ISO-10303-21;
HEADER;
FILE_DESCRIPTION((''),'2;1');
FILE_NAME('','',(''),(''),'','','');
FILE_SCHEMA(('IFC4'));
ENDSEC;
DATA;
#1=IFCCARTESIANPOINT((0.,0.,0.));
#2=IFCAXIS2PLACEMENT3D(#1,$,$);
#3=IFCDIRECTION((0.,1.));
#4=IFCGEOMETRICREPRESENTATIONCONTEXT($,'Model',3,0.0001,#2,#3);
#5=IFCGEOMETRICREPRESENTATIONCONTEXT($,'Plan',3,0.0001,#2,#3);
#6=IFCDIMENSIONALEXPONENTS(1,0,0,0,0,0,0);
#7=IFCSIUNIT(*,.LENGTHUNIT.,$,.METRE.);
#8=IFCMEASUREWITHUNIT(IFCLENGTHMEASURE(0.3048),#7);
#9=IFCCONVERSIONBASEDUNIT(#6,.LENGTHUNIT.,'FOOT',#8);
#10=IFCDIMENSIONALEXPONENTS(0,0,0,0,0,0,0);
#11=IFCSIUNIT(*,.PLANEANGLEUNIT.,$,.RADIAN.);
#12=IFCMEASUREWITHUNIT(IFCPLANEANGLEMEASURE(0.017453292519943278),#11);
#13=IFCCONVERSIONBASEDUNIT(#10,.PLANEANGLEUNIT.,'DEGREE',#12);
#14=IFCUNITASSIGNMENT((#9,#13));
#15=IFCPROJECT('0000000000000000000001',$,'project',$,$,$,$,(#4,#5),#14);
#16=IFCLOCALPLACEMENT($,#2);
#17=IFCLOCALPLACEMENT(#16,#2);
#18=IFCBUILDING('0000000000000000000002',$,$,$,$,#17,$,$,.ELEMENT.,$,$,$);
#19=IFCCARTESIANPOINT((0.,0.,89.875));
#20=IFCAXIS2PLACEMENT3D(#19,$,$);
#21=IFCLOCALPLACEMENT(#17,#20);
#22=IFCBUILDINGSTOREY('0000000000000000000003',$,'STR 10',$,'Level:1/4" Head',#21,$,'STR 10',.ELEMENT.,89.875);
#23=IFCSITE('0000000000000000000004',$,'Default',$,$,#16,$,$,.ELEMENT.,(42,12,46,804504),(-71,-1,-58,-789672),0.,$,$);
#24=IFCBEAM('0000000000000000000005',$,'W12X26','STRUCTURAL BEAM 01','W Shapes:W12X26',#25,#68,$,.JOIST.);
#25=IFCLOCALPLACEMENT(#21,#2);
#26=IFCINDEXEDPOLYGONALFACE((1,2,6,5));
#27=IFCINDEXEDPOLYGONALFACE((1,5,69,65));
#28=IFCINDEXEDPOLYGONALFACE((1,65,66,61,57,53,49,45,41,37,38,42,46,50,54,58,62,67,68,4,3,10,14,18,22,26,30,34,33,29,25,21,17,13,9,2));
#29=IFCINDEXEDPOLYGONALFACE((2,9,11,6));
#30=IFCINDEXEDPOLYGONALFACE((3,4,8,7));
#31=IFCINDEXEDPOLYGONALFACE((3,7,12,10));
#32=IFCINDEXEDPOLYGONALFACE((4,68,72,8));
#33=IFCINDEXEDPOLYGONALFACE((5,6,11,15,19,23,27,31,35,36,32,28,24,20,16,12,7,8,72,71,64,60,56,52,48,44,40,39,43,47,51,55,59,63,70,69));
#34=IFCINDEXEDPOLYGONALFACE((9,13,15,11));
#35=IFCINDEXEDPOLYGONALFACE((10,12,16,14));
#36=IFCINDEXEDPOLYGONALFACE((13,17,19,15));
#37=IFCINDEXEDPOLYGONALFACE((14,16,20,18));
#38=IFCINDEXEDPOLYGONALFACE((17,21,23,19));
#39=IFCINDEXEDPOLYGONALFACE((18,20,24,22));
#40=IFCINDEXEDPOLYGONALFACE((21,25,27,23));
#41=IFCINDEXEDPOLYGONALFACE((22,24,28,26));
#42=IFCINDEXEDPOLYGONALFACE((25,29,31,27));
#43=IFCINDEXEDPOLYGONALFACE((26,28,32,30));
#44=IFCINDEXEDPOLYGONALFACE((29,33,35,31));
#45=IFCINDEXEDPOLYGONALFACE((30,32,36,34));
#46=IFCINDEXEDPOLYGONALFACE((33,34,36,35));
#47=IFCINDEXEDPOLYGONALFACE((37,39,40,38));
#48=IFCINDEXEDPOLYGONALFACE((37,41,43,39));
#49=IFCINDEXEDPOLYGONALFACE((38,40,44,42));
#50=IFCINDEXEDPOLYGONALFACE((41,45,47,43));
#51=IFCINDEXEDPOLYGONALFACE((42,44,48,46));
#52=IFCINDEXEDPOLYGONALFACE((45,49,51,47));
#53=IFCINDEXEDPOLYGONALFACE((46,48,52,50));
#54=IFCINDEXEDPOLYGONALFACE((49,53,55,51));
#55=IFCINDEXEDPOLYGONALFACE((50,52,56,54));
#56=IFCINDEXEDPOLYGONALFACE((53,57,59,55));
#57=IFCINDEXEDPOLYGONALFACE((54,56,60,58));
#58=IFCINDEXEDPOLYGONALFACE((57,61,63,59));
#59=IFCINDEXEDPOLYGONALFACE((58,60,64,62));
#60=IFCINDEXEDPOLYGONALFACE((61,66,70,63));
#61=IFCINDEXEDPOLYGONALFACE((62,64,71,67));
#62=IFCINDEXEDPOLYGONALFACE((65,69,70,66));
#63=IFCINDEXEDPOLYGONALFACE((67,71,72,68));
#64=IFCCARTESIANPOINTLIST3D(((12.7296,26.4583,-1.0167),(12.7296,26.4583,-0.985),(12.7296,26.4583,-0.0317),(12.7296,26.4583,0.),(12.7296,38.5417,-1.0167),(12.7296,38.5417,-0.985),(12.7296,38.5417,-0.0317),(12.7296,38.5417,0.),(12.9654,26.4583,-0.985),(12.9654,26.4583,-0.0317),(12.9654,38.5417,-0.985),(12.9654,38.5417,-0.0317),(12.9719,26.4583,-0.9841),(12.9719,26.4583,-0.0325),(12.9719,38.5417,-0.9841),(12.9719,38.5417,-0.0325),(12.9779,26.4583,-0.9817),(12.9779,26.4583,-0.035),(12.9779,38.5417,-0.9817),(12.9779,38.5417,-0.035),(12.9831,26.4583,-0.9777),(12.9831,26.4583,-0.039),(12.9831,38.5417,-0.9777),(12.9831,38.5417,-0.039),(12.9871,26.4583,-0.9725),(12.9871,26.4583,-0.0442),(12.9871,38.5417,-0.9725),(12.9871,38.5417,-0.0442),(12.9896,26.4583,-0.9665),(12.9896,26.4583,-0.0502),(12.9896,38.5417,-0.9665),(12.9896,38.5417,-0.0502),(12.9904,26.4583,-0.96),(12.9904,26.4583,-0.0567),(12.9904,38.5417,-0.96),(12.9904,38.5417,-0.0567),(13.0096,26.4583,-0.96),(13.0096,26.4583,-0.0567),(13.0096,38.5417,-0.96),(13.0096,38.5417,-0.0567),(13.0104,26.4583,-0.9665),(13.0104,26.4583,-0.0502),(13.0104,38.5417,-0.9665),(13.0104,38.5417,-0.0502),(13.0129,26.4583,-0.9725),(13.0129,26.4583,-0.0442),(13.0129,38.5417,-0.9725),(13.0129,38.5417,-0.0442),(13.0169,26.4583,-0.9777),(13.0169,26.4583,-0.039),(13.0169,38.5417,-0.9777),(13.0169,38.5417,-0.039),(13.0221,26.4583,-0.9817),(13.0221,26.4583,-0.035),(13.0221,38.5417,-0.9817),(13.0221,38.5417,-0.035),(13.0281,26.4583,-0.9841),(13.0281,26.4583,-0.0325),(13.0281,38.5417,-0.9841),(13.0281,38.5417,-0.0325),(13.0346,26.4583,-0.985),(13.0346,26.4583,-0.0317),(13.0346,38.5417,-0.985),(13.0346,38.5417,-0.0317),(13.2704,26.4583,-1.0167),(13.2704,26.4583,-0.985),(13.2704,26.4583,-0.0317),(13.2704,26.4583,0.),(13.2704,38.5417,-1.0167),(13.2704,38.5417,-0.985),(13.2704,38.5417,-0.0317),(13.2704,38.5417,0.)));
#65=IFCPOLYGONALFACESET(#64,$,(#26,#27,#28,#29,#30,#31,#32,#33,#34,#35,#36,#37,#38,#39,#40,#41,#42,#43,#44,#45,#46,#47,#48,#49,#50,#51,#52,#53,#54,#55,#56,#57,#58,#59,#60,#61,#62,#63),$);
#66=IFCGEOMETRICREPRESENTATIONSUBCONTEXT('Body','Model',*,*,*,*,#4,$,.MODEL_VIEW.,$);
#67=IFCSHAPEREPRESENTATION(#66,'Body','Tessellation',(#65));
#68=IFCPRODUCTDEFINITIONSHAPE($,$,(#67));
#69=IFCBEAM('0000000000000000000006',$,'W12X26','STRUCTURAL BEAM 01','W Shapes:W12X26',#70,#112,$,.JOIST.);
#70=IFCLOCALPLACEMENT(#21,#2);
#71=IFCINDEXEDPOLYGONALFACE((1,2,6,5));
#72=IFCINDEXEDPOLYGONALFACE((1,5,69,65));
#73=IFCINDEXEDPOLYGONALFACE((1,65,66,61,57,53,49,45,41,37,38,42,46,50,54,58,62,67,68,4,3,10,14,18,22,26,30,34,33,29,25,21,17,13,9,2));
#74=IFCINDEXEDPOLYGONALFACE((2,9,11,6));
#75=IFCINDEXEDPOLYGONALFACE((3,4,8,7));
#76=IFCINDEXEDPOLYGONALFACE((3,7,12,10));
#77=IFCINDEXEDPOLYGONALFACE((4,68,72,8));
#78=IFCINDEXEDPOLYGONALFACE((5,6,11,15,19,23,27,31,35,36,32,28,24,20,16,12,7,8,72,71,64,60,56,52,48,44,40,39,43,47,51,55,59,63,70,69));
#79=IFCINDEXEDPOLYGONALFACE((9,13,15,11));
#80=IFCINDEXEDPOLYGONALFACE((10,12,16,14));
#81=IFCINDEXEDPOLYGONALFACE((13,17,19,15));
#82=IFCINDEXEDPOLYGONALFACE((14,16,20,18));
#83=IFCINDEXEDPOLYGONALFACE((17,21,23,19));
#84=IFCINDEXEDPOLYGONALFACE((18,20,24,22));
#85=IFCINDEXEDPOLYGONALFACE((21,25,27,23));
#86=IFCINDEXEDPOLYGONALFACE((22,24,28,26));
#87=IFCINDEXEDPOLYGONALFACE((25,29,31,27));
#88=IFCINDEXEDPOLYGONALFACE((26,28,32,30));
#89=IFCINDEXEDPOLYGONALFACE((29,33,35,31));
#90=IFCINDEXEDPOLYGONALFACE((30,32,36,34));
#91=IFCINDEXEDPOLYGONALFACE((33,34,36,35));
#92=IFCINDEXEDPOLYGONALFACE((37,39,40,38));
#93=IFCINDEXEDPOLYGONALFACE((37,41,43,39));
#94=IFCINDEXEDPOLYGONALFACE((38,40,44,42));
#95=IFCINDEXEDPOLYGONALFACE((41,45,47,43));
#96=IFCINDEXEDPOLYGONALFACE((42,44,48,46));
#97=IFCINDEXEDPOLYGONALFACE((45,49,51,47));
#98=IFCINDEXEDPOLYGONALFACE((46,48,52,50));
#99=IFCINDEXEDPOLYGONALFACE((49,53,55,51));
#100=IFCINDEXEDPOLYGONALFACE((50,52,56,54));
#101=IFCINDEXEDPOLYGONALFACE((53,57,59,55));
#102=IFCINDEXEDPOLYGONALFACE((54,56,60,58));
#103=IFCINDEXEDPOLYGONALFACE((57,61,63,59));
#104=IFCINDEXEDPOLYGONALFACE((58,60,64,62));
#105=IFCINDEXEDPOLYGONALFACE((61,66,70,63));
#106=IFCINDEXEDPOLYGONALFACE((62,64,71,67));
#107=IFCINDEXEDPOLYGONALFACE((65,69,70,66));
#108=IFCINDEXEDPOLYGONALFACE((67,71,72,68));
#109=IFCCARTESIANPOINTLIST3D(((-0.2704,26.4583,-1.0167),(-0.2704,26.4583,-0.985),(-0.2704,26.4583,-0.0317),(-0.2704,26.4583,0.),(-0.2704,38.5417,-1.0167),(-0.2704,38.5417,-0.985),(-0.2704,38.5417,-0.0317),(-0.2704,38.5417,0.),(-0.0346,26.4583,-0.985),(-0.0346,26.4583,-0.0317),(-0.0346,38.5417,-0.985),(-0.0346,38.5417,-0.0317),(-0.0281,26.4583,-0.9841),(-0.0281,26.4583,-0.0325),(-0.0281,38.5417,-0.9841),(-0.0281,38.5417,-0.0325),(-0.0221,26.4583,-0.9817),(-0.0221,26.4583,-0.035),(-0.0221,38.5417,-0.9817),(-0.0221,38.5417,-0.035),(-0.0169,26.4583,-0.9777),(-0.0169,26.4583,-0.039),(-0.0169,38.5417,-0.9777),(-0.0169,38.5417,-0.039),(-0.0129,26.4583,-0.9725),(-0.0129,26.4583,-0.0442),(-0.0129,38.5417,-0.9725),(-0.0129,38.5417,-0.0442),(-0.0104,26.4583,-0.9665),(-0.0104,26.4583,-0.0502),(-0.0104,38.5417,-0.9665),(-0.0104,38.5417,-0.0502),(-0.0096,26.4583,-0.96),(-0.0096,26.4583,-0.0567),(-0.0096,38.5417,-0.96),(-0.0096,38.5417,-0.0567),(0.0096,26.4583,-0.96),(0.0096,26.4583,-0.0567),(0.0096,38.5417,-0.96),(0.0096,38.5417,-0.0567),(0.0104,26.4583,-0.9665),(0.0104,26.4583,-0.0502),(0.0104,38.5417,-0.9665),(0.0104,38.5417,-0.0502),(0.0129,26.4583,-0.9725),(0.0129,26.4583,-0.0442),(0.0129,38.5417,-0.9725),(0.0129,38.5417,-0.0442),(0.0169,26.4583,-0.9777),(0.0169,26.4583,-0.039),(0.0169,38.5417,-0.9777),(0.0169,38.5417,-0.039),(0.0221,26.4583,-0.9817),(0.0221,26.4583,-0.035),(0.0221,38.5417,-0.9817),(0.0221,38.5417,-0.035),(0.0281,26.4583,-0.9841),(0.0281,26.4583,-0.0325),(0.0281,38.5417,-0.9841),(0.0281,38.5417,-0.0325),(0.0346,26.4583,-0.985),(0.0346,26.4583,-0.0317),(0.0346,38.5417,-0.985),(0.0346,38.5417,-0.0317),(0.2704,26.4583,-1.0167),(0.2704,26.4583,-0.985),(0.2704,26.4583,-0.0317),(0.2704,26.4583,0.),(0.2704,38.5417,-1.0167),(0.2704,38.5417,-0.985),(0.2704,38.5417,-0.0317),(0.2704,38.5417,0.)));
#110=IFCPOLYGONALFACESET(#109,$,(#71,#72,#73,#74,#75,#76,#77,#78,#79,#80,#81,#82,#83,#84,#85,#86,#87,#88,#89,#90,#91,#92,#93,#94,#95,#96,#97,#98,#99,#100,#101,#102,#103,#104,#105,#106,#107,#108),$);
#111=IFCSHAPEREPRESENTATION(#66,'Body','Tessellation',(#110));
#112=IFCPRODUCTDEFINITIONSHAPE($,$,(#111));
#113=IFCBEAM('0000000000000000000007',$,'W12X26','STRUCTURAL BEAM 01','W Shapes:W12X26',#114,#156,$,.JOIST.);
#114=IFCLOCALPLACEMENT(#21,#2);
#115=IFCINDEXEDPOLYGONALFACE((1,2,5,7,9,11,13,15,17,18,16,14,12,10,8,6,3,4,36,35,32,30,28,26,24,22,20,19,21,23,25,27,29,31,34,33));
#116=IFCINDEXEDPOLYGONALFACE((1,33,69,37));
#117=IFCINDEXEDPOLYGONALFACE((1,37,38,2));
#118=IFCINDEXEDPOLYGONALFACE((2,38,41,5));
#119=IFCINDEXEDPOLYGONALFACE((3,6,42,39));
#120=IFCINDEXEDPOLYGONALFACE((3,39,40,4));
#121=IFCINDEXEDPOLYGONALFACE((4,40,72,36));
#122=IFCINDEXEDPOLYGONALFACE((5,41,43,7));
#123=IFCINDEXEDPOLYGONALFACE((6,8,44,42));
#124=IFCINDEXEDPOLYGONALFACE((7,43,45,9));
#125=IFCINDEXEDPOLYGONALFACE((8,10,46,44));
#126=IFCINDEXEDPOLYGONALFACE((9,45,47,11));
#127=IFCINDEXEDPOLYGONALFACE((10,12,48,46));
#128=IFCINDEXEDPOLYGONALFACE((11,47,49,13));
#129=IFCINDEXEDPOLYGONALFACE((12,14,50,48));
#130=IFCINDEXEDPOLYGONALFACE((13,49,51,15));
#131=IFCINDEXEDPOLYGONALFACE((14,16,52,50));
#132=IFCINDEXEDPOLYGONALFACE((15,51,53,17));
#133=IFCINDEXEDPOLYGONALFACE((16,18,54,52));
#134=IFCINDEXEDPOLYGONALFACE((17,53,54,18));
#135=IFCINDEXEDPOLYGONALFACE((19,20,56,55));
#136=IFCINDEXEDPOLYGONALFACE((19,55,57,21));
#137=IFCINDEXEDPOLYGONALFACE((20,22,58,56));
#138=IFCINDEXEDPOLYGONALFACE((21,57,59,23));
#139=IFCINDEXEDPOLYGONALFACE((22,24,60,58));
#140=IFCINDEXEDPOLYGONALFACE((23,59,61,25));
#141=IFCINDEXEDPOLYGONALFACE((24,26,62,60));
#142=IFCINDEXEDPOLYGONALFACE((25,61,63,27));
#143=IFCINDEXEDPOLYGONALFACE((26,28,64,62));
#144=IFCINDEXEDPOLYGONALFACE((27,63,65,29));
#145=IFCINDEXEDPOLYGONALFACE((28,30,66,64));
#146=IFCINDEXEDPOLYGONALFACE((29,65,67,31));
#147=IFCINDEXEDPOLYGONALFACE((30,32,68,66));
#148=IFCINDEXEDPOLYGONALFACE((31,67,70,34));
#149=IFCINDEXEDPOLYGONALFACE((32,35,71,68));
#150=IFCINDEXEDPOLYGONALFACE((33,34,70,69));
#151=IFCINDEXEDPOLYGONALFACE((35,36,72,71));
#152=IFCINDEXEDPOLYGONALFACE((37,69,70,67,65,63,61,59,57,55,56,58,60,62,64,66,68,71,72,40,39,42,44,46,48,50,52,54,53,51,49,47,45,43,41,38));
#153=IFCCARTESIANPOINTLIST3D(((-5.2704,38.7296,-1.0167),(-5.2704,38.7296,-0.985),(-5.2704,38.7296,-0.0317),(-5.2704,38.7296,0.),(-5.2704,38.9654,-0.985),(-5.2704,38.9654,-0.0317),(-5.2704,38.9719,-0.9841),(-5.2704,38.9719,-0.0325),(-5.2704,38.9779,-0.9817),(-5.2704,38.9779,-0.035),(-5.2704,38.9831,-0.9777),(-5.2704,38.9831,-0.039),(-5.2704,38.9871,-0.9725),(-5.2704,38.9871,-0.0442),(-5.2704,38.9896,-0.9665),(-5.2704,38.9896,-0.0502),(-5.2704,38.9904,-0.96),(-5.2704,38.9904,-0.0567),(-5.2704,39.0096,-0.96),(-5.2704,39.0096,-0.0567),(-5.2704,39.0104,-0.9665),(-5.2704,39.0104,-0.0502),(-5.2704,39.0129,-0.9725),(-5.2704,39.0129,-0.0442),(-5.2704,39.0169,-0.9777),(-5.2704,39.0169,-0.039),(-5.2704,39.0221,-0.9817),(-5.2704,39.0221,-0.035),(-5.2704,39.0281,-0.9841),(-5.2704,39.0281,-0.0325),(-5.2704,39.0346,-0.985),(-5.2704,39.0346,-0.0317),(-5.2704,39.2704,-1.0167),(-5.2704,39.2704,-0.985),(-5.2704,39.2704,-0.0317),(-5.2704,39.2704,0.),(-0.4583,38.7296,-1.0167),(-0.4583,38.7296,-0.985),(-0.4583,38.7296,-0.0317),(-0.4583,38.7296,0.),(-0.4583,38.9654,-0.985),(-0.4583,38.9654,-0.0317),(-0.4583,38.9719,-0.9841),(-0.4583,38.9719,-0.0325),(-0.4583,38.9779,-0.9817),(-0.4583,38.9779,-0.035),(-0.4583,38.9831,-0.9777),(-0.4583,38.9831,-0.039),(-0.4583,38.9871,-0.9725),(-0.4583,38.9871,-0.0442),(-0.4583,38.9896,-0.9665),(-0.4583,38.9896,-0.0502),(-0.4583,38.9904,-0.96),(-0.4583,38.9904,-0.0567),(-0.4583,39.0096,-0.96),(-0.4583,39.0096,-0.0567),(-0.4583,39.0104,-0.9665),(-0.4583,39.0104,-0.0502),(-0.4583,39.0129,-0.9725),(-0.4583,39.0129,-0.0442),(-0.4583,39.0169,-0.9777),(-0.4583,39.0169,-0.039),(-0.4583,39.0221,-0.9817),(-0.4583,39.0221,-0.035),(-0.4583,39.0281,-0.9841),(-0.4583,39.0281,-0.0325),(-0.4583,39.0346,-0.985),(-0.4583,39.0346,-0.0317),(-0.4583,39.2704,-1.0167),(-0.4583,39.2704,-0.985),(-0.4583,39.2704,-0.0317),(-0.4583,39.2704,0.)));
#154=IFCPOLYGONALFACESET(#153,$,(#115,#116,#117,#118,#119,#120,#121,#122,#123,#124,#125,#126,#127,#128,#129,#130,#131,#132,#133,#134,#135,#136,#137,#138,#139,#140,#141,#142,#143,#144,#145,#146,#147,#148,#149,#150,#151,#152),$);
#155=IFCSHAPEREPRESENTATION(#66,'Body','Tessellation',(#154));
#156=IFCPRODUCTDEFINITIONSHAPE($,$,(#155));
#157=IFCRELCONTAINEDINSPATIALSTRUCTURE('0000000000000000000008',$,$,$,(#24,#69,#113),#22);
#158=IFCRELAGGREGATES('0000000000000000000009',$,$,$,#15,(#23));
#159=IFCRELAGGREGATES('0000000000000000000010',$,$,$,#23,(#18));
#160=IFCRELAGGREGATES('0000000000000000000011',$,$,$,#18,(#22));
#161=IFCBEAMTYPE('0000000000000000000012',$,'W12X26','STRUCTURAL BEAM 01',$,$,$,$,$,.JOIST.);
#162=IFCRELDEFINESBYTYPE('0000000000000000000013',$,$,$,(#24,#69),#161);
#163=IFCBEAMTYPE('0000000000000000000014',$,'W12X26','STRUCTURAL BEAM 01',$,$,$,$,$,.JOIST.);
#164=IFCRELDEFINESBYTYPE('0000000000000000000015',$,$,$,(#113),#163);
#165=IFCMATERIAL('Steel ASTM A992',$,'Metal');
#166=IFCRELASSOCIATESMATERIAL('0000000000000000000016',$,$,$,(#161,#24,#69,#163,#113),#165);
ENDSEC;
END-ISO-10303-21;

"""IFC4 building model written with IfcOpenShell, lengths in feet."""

from ifc_helpers import new_model, entity, si_unit, converted_unit, direction, frame, origin, place, context, subcontext, project, spatial, line, arc, indexed_curve, outline, extrude, source, transform, mapped, material, type_object, type_shapes, element, save


model = new_model("IFC4")

# Units and contexts
model_context = context("Model", 3, precision=0.0001, world=origin(), true_north=direction((0.0, 1.0)))
plan_context = context("Plan", 3, precision=0.0001, world=origin(), true_north=direction((0.0, 1.0)))
body_context = subcontext(model_context, "Body", "Model", "MODEL_VIEW")
ifc_project = project(units=[converted_unit("LENGTHUNIT", "FOOT", entity("IfcLengthMeasure", 0.3048), si_unit("LENGTHUNIT", "METRE"), dimensions=[1, 0, 0, 0, 0, 0, 0]), converted_unit("PLANEANGLEUNIT", "DEGREE", entity("IfcPlaneAngleMeasure", 0.017453292519943278), si_unit("PLANEANGLEUNIT", "RADIAN"), dimensions=[0, 0, 0, 0, 0, 0, 0])], contexts=[model_context, plan_context])

# Site, building, storey
site_placement = place(None, origin())
site = spatial("IfcSite", under=ifc_project, at=site_placement, Name="Default", CompositionType="ELEMENT", RefLatitude=(42, 12, 46, 804504), RefLongitude=(-71, -1, -58, -789672), RefElevation=0.0)
building_placement = place(site_placement, origin())
building = spatial("IfcBuilding", under=site, at=building_placement, CompositionType="ELEMENT")
storey_placement = place(building_placement, frame((0.0, 0.0, 89.875)))
storey = spatial("IfcBuildingStorey", under=building, at=storey_placement, Name="STR 10", ObjectType="Level:1/4\" Head", LongName="STR 10", CompositionType="ELEMENT", Elevation=89.875)

# Beams
ifc_material = material(Name="Steel ASTM A992", Category="Metal")
beam_type_1 = type_object("IfcBeamType", Name="W12X26", Description="STRUCTURAL BEAM 01", PredefinedType="JOIST", material=ifc_material)
shared_shape_1 = source(origin(), body_context, "Body", "SweptSolid", [
    extrude(outline(indexed_curve([(-0.2704, -0.4767), (-0.2704, -0.5083), (0.2704, -0.5083), (0.2704, -0.4767), (0.0346, -0.4767), (0.0169, -0.4693), (0.0096, -0.4517), (0.0096, 0.4517), (0.0169, 0.4693), (0.0346, 0.4767), (0.2704, 0.4767), (0.2704, 0.5083), (-0.2704, 0.5083), (-0.2704, 0.4767), (-0.0346, 0.4767), (-0.0169, 0.4693), (-0.0096, 0.4517), (-0.0096, -0.4517), (-0.0169, -0.4693), (-0.0346, -0.4767)], segments=[line(1, 2, 3, 4, 5), arc(5, 6, 7), line(7, 8), arc(8, 9, 10), line(10, 11, 12, 13, 14, 15), arc(15, 16, 17), line(17, 18), arc(18, 19, 20), line(20, 1)], self_intersect=False)), frame((-6.165, 0.0, 0.0), z_axis=(-1.0, 0.0, 0.0), x_axis=(0.0, -1.0, 0.0)), (0.0, 0.0, -1.0), 12.0833),
])
type_shapes(beam_type_1, [shared_shape_1])
for number, where, z_axis, x_axis, name in (
    (1, (13.0, 32.6234, -0.5083), (0.0, 0.0, 1.0), (0.0, 1.0, 0.0), "W12X26"),
    (2, (0.0, 32.6234, -0.5083), (0.0, 0.0, 1.0), (0.0, 1.0, 0.0), "W12X26"),
):
    element("IfcBeam", number, at=place(storey_placement, frame(where, z_axis=z_axis, x_axis=x_axis)), inside=storey, type_object=beam_type_1, material=ifc_material, Name=name, Description="STRUCTURAL BEAM 01", ObjectType="W Shapes:W12X26", PredefinedType="JOIST", context=body_context, shape_type="MappedRepresentation", body=[
        mapped(shared_shape_1, transform((0.0, 0.0, 0.0), scale=1.0)),
    ])
beam_type_2 = type_object("IfcBeamType", Name="W12X26", Description="STRUCTURAL BEAM 01", PredefinedType="JOIST", material=ifc_material)
shared_shape_2 = source(origin(), body_context, "Body", "SweptSolid", [
    extrude(outline(indexed_curve([(0.4767, -0.2704), (0.5083, -0.2704), (0.5083, 0.2704), (0.4767, 0.2704), (0.4767, 0.0346), (0.4693, 0.0169), (0.4517, 0.0096), (-0.4517, 0.0096), (-0.4693, 0.0169), (-0.4767, 0.0346), (-0.4767, 0.2704), (-0.5083, 0.2704), (-0.5083, -0.2704), (-0.4767, -0.2704), (-0.4767, -0.0346), (-0.4693, -0.0169), (-0.4517, -0.0096), (0.4517, -0.0096), (0.4693, -0.0169), (0.4767, -0.0346)], segments=[line(1, 2, 3, 4, 5), arc(5, 6, 7), line(7, 8), arc(8, 9, 10), line(10, 11, 12, 13, 14, 15), arc(15, 16, 17), line(17, 18), arc(18, 19, 20), line(20, 1)], self_intersect=False)), frame((-2.0417, 0.0, 0.0), z_axis=(1.0, 0.0, 0.0), x_axis=(0.0, 0.0, -1.0)), (0.0, 0.0, 1.0), 4.8121),
])
type_shapes(beam_type_2, [shared_shape_2])
for number, where, z_axis, x_axis, name in (
    (3, (-2.5, 39.0, -0.5083), (0.0, 0.0, 1.0), (-1.0, 0.0, 0.0), "W12X26"),
):
    element("IfcBeam", number, at=place(storey_placement, frame(where, z_axis=z_axis, x_axis=x_axis)), inside=storey, type_object=beam_type_2, material=ifc_material, Name=name, Description="STRUCTURAL BEAM 01", ObjectType="W Shapes:W12X26", PredefinedType="JOIST", context=body_context, shape_type="MappedRepresentation", body=[
        mapped(shared_shape_2, transform((0.0, 0.0, 0.0), scale=1.0)),
    ])

save(model, "model.ifc")
